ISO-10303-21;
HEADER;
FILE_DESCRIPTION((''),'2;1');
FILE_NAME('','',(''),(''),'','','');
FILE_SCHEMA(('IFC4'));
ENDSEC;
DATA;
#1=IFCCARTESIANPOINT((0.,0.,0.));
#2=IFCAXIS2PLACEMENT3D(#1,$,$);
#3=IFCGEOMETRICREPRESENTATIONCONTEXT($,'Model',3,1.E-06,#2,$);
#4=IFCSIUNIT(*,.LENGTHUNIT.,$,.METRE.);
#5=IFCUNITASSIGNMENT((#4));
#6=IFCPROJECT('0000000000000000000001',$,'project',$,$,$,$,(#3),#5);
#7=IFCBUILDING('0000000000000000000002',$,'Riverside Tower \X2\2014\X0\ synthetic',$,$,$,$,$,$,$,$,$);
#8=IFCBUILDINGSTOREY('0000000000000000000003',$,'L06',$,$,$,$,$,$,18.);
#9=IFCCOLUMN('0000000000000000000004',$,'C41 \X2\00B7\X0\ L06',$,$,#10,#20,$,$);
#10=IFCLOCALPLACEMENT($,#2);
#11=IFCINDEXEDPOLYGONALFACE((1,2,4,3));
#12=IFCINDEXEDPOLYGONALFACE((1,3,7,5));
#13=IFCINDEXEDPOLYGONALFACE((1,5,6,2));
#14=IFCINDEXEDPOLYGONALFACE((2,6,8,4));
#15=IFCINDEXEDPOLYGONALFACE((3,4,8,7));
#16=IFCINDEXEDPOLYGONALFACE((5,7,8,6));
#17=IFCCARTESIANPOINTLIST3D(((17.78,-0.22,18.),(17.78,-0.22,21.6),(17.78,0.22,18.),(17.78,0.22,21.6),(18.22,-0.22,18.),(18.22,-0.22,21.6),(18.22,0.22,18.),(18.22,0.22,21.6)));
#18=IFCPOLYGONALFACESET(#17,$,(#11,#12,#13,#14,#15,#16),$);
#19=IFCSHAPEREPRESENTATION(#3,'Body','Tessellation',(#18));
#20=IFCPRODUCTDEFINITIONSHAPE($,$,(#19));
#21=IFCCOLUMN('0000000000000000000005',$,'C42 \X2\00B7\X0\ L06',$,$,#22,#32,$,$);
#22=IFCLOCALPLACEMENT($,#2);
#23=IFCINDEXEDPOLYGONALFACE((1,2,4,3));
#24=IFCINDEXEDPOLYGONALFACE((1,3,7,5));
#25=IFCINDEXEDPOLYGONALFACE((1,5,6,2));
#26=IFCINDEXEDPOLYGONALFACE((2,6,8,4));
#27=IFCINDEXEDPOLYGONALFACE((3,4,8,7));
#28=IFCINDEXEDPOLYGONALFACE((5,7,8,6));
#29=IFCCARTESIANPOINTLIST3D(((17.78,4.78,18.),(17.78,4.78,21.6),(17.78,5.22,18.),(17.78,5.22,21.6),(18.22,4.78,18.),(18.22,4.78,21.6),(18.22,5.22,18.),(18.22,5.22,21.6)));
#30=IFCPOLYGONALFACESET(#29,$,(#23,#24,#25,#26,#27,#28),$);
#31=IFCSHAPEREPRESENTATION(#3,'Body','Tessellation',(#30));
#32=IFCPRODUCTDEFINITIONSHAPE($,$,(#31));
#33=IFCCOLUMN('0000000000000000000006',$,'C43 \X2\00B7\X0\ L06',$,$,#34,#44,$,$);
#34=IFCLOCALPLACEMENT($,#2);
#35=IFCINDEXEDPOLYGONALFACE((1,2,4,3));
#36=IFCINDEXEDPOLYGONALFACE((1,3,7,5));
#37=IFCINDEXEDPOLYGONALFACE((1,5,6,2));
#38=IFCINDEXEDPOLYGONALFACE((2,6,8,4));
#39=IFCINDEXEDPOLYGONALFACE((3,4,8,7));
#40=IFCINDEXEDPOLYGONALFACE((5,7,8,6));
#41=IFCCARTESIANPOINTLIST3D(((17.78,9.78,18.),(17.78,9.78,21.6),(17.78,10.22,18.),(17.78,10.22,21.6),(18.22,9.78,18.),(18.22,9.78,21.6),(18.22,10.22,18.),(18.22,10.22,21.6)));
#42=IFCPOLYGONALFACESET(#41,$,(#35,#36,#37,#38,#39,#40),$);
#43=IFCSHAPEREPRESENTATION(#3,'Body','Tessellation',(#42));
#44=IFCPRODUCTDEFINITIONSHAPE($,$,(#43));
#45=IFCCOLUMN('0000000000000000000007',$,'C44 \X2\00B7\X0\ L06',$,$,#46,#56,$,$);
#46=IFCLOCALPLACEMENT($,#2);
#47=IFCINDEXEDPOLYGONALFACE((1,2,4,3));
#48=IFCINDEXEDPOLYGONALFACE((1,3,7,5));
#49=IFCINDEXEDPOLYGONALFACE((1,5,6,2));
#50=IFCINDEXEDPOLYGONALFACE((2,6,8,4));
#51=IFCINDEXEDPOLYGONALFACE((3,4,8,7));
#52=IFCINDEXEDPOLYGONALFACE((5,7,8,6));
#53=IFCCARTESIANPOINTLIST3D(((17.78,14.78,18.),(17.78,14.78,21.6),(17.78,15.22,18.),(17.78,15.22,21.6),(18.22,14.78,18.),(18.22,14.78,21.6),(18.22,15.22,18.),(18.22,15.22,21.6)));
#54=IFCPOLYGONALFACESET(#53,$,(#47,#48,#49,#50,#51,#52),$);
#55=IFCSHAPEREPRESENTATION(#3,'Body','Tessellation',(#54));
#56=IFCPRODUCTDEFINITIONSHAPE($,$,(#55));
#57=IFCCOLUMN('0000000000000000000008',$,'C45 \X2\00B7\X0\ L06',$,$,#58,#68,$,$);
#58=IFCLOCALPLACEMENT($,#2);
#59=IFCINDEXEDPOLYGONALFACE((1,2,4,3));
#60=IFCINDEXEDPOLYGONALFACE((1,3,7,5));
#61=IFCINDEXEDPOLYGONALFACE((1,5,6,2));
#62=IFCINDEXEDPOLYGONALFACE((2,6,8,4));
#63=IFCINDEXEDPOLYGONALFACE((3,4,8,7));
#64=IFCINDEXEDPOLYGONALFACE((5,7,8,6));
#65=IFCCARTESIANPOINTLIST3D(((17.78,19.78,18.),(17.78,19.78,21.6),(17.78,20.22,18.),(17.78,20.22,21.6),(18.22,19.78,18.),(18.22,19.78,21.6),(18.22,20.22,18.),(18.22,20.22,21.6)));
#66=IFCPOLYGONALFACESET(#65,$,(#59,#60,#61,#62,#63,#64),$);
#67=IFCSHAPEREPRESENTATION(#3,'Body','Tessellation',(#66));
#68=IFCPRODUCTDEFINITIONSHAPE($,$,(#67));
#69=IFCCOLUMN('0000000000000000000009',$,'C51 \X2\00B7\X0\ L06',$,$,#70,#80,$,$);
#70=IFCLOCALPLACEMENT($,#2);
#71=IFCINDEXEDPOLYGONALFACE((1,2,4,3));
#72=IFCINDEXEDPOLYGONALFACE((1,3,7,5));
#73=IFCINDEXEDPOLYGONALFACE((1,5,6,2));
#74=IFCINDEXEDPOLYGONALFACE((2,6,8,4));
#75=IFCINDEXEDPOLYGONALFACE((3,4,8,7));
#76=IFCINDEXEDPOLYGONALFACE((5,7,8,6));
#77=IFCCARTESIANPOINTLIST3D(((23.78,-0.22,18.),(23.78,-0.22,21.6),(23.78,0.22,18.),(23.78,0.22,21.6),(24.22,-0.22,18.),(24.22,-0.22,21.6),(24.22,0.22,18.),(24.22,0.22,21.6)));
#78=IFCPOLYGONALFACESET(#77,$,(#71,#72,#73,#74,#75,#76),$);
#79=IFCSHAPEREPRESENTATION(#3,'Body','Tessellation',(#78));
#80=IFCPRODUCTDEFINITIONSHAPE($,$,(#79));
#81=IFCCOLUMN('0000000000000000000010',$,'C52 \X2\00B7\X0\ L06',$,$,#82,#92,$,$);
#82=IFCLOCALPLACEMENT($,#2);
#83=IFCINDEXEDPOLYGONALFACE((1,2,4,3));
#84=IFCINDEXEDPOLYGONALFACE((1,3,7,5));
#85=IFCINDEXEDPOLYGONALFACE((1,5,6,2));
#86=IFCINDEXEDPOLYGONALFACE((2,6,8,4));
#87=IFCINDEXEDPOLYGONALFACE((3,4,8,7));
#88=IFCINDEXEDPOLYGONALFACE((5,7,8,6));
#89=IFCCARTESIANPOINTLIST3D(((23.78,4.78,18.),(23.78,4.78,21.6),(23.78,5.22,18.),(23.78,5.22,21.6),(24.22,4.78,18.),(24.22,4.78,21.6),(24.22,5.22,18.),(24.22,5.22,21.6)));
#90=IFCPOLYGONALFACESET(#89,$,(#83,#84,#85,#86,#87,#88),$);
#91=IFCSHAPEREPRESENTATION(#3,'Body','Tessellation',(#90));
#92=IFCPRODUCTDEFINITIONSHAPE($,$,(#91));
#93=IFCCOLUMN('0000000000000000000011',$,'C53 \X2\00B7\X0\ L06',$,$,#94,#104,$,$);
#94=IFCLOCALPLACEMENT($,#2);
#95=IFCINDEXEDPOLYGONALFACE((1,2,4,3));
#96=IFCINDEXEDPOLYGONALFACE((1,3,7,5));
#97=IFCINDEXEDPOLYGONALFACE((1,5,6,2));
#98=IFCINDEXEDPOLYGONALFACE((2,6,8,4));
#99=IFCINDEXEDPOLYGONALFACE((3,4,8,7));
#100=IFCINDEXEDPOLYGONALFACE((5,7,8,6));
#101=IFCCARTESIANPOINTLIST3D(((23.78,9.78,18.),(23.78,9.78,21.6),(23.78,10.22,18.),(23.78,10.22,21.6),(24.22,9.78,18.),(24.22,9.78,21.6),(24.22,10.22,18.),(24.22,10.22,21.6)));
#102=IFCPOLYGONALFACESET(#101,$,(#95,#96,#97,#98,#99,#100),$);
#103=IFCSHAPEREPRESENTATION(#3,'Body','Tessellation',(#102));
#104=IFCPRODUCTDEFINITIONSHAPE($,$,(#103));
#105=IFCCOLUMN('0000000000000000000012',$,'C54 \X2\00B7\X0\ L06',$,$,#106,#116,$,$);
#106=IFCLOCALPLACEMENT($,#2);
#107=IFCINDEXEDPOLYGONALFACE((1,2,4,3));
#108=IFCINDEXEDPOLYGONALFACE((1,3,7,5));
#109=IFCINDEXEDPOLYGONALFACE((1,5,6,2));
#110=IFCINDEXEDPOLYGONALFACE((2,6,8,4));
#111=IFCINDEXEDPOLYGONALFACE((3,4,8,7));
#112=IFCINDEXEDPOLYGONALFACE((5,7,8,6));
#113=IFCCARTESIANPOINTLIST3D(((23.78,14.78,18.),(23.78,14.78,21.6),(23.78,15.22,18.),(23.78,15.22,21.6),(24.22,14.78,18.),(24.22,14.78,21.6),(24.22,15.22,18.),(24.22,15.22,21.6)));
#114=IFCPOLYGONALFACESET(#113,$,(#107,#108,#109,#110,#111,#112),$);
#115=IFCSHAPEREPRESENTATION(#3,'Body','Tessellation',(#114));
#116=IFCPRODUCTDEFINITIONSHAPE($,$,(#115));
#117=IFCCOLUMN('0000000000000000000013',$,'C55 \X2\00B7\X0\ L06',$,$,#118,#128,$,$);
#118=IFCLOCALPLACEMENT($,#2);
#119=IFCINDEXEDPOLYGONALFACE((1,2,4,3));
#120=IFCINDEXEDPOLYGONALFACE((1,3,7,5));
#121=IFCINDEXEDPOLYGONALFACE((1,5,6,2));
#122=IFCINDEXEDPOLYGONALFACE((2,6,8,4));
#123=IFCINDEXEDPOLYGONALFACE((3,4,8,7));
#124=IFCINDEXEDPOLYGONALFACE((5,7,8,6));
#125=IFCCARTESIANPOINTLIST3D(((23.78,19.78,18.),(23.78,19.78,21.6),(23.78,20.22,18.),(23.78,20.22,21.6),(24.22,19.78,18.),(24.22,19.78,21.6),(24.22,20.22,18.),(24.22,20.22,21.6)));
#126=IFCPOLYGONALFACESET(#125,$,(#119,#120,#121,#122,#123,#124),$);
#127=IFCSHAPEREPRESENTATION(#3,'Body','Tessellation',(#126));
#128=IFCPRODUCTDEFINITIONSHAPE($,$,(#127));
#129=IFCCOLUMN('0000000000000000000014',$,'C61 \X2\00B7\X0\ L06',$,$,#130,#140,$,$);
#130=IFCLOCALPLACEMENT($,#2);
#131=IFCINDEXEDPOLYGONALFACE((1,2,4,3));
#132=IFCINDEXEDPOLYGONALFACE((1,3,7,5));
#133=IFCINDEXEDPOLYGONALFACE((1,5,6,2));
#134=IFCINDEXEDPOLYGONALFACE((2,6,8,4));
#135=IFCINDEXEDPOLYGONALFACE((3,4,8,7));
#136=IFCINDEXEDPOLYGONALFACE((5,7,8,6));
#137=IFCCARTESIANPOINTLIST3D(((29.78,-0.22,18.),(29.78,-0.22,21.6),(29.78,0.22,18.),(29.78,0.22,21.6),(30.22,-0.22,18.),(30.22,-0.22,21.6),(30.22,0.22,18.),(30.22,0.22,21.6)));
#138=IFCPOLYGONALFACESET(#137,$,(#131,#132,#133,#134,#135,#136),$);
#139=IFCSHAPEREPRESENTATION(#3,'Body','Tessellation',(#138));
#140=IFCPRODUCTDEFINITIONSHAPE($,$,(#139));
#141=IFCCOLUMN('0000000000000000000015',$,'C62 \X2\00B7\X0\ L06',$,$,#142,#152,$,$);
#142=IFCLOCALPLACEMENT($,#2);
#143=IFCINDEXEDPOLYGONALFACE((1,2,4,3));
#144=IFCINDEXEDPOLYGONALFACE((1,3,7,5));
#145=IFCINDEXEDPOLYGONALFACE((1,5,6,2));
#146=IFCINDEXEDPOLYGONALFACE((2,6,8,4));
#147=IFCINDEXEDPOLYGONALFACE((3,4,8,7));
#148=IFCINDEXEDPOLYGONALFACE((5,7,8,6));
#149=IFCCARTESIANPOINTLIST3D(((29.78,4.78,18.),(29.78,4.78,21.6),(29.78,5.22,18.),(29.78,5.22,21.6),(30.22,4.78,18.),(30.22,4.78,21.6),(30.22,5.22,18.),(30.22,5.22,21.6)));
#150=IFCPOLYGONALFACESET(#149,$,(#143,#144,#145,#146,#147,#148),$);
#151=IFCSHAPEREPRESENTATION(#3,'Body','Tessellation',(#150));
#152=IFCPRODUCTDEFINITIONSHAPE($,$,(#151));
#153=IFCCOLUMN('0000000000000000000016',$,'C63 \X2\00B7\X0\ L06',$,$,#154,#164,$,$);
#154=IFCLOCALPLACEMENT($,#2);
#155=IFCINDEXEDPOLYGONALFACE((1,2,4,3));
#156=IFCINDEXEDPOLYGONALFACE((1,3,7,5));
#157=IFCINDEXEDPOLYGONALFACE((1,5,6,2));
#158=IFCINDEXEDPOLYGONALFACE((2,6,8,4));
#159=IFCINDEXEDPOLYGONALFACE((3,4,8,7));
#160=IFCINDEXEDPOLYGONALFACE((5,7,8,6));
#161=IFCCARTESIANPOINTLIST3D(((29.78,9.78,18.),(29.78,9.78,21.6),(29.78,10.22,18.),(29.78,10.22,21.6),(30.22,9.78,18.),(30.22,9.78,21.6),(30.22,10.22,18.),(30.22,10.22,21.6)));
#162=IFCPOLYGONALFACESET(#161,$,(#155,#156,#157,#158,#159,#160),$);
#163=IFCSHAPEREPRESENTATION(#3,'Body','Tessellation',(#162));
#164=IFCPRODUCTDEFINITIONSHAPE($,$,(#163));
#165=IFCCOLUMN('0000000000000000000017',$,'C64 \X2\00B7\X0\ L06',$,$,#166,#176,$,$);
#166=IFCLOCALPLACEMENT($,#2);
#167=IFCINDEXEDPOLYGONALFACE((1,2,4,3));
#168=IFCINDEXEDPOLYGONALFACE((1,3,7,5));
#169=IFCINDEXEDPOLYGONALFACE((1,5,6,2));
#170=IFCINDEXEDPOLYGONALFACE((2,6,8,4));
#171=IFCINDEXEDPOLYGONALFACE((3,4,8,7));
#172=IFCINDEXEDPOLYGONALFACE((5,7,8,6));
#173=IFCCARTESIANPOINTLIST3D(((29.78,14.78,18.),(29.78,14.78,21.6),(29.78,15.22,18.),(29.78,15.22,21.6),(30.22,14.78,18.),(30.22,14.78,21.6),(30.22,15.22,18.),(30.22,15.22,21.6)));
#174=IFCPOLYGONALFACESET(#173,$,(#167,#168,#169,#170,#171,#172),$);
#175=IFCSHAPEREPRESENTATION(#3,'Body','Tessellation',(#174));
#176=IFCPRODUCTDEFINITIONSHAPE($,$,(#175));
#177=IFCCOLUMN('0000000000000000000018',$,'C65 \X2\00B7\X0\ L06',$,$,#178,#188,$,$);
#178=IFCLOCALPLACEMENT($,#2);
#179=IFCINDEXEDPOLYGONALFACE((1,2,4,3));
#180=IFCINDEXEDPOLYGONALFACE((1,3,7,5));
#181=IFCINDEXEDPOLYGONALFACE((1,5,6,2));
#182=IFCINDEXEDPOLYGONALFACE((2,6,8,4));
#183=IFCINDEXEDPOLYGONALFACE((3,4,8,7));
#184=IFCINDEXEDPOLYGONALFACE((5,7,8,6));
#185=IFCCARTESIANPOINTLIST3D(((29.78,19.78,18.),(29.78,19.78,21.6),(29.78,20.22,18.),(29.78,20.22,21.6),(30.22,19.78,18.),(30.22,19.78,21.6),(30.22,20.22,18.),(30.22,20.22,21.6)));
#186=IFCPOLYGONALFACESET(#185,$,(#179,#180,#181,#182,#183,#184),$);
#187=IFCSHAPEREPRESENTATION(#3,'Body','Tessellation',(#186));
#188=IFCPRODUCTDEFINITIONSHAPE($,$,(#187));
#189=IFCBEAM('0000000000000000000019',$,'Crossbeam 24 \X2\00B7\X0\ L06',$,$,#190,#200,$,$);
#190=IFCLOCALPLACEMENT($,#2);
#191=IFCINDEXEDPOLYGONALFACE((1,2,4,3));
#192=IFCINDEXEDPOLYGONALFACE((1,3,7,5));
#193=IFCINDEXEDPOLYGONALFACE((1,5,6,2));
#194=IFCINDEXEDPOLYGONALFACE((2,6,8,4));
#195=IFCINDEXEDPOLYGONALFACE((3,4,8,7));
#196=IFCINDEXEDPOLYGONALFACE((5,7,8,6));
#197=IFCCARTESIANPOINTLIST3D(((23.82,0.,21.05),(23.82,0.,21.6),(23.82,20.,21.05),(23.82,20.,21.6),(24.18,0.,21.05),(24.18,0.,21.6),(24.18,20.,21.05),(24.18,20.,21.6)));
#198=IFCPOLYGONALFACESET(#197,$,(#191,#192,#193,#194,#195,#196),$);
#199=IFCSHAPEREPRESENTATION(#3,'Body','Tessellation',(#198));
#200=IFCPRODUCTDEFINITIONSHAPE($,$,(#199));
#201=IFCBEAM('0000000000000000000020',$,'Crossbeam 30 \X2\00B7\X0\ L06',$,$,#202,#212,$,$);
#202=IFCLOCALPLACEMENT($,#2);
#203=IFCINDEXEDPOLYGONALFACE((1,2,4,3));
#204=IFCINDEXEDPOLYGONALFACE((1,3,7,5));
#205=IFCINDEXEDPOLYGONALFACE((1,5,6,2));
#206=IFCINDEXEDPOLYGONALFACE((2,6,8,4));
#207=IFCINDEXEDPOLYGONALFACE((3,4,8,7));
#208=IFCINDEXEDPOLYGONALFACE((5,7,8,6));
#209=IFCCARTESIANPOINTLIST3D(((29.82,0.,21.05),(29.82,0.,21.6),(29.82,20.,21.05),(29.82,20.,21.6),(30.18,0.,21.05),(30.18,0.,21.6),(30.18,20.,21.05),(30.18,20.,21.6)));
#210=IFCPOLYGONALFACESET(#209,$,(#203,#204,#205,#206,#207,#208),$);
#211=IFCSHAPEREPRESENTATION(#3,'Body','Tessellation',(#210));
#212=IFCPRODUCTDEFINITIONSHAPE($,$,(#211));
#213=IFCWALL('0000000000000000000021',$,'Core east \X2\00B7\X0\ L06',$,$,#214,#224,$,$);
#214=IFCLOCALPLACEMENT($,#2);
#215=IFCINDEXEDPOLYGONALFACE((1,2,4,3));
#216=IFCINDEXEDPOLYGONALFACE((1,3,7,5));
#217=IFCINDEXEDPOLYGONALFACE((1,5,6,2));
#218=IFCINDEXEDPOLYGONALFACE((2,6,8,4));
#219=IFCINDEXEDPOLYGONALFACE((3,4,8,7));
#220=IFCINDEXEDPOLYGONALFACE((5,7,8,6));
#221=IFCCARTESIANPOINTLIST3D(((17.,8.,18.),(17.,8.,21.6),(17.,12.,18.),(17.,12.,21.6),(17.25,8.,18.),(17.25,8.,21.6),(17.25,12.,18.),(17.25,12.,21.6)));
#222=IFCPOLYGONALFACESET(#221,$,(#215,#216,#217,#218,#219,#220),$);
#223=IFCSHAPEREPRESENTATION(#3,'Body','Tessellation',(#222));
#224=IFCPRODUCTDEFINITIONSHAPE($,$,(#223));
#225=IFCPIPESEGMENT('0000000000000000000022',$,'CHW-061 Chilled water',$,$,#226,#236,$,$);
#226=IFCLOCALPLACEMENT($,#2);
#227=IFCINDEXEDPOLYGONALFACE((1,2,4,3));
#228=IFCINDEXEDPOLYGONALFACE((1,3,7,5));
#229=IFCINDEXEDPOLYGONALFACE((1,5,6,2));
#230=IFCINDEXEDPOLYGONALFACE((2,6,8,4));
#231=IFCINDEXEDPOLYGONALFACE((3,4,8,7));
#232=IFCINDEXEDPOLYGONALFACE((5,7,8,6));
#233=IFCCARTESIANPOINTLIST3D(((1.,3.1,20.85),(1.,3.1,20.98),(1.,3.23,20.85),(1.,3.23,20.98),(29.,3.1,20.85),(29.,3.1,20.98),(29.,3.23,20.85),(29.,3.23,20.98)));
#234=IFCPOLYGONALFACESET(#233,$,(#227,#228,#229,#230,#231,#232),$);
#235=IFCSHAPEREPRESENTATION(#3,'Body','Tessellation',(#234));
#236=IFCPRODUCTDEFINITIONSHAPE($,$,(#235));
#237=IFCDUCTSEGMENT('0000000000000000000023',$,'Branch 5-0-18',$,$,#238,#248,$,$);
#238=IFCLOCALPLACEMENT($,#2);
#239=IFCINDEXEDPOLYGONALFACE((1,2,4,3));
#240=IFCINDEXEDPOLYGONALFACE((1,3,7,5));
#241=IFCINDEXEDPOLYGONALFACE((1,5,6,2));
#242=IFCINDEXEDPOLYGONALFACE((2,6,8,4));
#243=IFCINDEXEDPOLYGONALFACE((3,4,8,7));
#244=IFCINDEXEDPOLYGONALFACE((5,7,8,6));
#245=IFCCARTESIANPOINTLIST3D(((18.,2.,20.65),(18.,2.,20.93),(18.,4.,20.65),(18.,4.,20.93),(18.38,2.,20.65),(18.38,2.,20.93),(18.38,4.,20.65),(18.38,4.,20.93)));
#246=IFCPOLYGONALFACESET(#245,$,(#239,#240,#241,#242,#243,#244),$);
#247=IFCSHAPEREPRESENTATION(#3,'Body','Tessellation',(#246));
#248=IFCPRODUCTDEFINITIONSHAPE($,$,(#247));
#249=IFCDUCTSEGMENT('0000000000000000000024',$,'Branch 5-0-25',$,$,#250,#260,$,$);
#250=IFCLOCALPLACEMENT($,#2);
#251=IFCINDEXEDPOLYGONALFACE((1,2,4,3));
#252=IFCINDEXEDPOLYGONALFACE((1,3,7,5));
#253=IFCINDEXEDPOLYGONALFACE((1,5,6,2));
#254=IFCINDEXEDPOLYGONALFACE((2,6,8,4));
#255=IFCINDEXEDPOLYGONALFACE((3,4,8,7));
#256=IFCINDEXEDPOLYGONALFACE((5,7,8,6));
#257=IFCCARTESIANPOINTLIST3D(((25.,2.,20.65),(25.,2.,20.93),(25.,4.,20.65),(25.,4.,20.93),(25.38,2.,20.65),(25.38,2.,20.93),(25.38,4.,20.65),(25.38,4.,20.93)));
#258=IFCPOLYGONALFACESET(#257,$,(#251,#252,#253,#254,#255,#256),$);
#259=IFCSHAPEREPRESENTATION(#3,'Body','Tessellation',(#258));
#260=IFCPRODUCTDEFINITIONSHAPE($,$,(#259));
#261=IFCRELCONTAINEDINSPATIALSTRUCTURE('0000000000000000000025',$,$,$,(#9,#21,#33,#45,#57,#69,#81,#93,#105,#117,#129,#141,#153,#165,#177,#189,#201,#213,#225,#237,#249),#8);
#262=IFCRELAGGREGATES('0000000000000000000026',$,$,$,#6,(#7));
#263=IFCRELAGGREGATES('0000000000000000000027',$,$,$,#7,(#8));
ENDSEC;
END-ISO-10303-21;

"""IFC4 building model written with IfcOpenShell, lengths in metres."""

from ifc_helpers import new_model, si_unit, frame, origin, place, context, project, spatial, rectangle, extrude, element, save


model = new_model("IFC4")

# Units and contexts
model_context = context("Model", 3, precision=1e-06, world=origin())
ifc_project = project(units=[si_unit("LENGTHUNIT", "METRE")], contexts=[model_context])

# Building, storey
building = spatial("IfcBuilding", under=ifc_project, Name="Riverside Tower — synthetic")
storey = spatial("IfcBuildingStorey", under=building, Name="L06", Elevation=18.0)

# Columns
for number, where, name in (
    (1, (18.0, 0.0, 18.0), "C41 · L06"),
    (2, (18.0, 5.0, 18.0), "C42 · L06"),
    (3, (18.0, 10.0, 18.0), "C43 · L06"),
    (4, (18.0, 15.0, 18.0), "C44 · L06"),
    (5, (18.0, 20.0, 18.0), "C45 · L06"),
    (6, (24.0, 0.0, 18.0), "C51 · L06"),
    (7, (24.0, 5.0, 18.0), "C52 · L06"),
    (8, (24.0, 10.0, 18.0), "C53 · L06"),
    (9, (24.0, 15.0, 18.0), "C54 · L06"),
    (10, (24.0, 20.0, 18.0), "C55 · L06"),
    (11, (30.0, 0.0, 18.0), "C61 · L06"),
    (12, (30.0, 5.0, 18.0), "C62 · L06"),
    (13, (30.0, 10.0, 18.0), "C63 · L06"),
    (14, (30.0, 15.0, 18.0), "C64 · L06"),
    (15, (30.0, 20.0, 18.0), "C65 · L06"),
):
    element("IfcColumn", number, at=place(None, frame(where)), inside=storey, Name=name, context=model_context, shape_type="SweptSolid", body=[
        extrude(rectangle(XDim=0.44, YDim=0.44), origin(), (0.0, 0.0, 1.0), 3.6),
    ])

# Beams
for number, where, name in (
    (16, (24.0, 10.0, 21.05), "Crossbeam 24 · L06"),
    (17, (30.0, 10.0, 21.05), "Crossbeam 30 · L06"),
):
    element("IfcBeam", number, at=place(None, frame(where)), inside=storey, Name=name, context=model_context, shape_type="SweptSolid", body=[
        extrude(rectangle(XDim=0.36, YDim=20.0), origin(), (0.0, 0.0, 1.0), 0.55),
    ])

# Wall
wall_placement = place(None, frame((17.125, 10.0, 18.0)))
element("IfcWall", 18, at=wall_placement, inside=storey, Name="Core east · L06", context=model_context, shape_type="SweptSolid", body=[
    extrude(rectangle(XDim=0.25, YDim=4.0), origin(), (0.0, 0.0, 1.0), 3.6),
])

# Pipe segment
pipe_segment_1_placement = place(None, frame((15.0, 3.165, 20.85)))
element("IfcPipeSegment", 19, at=pipe_segment_1_placement, inside=storey, Name="CHW-061 Chilled water", context=model_context, shape_type="SweptSolid", body=[
    extrude(rectangle(XDim=28.0, YDim=0.13), origin(), (0.0, 0.0, 1.0), 0.13),
])

# Duct segments
for number, where, name in (
    (20, (18.19, 3.0, 20.65), "Branch 5-0-18"),
    (21, (25.19, 3.0, 20.65), "Branch 5-0-25"),
):
    element("IfcDuctSegment", number, at=place(None, frame(where)), inside=storey, Name=name, context=model_context, shape_type="SweptSolid", body=[
        extrude(rectangle(XDim=0.38, YDim=2.0), origin(), (0.0, 0.0, 1.0), 0.28),
    ])

save(model, "model.ifc")
